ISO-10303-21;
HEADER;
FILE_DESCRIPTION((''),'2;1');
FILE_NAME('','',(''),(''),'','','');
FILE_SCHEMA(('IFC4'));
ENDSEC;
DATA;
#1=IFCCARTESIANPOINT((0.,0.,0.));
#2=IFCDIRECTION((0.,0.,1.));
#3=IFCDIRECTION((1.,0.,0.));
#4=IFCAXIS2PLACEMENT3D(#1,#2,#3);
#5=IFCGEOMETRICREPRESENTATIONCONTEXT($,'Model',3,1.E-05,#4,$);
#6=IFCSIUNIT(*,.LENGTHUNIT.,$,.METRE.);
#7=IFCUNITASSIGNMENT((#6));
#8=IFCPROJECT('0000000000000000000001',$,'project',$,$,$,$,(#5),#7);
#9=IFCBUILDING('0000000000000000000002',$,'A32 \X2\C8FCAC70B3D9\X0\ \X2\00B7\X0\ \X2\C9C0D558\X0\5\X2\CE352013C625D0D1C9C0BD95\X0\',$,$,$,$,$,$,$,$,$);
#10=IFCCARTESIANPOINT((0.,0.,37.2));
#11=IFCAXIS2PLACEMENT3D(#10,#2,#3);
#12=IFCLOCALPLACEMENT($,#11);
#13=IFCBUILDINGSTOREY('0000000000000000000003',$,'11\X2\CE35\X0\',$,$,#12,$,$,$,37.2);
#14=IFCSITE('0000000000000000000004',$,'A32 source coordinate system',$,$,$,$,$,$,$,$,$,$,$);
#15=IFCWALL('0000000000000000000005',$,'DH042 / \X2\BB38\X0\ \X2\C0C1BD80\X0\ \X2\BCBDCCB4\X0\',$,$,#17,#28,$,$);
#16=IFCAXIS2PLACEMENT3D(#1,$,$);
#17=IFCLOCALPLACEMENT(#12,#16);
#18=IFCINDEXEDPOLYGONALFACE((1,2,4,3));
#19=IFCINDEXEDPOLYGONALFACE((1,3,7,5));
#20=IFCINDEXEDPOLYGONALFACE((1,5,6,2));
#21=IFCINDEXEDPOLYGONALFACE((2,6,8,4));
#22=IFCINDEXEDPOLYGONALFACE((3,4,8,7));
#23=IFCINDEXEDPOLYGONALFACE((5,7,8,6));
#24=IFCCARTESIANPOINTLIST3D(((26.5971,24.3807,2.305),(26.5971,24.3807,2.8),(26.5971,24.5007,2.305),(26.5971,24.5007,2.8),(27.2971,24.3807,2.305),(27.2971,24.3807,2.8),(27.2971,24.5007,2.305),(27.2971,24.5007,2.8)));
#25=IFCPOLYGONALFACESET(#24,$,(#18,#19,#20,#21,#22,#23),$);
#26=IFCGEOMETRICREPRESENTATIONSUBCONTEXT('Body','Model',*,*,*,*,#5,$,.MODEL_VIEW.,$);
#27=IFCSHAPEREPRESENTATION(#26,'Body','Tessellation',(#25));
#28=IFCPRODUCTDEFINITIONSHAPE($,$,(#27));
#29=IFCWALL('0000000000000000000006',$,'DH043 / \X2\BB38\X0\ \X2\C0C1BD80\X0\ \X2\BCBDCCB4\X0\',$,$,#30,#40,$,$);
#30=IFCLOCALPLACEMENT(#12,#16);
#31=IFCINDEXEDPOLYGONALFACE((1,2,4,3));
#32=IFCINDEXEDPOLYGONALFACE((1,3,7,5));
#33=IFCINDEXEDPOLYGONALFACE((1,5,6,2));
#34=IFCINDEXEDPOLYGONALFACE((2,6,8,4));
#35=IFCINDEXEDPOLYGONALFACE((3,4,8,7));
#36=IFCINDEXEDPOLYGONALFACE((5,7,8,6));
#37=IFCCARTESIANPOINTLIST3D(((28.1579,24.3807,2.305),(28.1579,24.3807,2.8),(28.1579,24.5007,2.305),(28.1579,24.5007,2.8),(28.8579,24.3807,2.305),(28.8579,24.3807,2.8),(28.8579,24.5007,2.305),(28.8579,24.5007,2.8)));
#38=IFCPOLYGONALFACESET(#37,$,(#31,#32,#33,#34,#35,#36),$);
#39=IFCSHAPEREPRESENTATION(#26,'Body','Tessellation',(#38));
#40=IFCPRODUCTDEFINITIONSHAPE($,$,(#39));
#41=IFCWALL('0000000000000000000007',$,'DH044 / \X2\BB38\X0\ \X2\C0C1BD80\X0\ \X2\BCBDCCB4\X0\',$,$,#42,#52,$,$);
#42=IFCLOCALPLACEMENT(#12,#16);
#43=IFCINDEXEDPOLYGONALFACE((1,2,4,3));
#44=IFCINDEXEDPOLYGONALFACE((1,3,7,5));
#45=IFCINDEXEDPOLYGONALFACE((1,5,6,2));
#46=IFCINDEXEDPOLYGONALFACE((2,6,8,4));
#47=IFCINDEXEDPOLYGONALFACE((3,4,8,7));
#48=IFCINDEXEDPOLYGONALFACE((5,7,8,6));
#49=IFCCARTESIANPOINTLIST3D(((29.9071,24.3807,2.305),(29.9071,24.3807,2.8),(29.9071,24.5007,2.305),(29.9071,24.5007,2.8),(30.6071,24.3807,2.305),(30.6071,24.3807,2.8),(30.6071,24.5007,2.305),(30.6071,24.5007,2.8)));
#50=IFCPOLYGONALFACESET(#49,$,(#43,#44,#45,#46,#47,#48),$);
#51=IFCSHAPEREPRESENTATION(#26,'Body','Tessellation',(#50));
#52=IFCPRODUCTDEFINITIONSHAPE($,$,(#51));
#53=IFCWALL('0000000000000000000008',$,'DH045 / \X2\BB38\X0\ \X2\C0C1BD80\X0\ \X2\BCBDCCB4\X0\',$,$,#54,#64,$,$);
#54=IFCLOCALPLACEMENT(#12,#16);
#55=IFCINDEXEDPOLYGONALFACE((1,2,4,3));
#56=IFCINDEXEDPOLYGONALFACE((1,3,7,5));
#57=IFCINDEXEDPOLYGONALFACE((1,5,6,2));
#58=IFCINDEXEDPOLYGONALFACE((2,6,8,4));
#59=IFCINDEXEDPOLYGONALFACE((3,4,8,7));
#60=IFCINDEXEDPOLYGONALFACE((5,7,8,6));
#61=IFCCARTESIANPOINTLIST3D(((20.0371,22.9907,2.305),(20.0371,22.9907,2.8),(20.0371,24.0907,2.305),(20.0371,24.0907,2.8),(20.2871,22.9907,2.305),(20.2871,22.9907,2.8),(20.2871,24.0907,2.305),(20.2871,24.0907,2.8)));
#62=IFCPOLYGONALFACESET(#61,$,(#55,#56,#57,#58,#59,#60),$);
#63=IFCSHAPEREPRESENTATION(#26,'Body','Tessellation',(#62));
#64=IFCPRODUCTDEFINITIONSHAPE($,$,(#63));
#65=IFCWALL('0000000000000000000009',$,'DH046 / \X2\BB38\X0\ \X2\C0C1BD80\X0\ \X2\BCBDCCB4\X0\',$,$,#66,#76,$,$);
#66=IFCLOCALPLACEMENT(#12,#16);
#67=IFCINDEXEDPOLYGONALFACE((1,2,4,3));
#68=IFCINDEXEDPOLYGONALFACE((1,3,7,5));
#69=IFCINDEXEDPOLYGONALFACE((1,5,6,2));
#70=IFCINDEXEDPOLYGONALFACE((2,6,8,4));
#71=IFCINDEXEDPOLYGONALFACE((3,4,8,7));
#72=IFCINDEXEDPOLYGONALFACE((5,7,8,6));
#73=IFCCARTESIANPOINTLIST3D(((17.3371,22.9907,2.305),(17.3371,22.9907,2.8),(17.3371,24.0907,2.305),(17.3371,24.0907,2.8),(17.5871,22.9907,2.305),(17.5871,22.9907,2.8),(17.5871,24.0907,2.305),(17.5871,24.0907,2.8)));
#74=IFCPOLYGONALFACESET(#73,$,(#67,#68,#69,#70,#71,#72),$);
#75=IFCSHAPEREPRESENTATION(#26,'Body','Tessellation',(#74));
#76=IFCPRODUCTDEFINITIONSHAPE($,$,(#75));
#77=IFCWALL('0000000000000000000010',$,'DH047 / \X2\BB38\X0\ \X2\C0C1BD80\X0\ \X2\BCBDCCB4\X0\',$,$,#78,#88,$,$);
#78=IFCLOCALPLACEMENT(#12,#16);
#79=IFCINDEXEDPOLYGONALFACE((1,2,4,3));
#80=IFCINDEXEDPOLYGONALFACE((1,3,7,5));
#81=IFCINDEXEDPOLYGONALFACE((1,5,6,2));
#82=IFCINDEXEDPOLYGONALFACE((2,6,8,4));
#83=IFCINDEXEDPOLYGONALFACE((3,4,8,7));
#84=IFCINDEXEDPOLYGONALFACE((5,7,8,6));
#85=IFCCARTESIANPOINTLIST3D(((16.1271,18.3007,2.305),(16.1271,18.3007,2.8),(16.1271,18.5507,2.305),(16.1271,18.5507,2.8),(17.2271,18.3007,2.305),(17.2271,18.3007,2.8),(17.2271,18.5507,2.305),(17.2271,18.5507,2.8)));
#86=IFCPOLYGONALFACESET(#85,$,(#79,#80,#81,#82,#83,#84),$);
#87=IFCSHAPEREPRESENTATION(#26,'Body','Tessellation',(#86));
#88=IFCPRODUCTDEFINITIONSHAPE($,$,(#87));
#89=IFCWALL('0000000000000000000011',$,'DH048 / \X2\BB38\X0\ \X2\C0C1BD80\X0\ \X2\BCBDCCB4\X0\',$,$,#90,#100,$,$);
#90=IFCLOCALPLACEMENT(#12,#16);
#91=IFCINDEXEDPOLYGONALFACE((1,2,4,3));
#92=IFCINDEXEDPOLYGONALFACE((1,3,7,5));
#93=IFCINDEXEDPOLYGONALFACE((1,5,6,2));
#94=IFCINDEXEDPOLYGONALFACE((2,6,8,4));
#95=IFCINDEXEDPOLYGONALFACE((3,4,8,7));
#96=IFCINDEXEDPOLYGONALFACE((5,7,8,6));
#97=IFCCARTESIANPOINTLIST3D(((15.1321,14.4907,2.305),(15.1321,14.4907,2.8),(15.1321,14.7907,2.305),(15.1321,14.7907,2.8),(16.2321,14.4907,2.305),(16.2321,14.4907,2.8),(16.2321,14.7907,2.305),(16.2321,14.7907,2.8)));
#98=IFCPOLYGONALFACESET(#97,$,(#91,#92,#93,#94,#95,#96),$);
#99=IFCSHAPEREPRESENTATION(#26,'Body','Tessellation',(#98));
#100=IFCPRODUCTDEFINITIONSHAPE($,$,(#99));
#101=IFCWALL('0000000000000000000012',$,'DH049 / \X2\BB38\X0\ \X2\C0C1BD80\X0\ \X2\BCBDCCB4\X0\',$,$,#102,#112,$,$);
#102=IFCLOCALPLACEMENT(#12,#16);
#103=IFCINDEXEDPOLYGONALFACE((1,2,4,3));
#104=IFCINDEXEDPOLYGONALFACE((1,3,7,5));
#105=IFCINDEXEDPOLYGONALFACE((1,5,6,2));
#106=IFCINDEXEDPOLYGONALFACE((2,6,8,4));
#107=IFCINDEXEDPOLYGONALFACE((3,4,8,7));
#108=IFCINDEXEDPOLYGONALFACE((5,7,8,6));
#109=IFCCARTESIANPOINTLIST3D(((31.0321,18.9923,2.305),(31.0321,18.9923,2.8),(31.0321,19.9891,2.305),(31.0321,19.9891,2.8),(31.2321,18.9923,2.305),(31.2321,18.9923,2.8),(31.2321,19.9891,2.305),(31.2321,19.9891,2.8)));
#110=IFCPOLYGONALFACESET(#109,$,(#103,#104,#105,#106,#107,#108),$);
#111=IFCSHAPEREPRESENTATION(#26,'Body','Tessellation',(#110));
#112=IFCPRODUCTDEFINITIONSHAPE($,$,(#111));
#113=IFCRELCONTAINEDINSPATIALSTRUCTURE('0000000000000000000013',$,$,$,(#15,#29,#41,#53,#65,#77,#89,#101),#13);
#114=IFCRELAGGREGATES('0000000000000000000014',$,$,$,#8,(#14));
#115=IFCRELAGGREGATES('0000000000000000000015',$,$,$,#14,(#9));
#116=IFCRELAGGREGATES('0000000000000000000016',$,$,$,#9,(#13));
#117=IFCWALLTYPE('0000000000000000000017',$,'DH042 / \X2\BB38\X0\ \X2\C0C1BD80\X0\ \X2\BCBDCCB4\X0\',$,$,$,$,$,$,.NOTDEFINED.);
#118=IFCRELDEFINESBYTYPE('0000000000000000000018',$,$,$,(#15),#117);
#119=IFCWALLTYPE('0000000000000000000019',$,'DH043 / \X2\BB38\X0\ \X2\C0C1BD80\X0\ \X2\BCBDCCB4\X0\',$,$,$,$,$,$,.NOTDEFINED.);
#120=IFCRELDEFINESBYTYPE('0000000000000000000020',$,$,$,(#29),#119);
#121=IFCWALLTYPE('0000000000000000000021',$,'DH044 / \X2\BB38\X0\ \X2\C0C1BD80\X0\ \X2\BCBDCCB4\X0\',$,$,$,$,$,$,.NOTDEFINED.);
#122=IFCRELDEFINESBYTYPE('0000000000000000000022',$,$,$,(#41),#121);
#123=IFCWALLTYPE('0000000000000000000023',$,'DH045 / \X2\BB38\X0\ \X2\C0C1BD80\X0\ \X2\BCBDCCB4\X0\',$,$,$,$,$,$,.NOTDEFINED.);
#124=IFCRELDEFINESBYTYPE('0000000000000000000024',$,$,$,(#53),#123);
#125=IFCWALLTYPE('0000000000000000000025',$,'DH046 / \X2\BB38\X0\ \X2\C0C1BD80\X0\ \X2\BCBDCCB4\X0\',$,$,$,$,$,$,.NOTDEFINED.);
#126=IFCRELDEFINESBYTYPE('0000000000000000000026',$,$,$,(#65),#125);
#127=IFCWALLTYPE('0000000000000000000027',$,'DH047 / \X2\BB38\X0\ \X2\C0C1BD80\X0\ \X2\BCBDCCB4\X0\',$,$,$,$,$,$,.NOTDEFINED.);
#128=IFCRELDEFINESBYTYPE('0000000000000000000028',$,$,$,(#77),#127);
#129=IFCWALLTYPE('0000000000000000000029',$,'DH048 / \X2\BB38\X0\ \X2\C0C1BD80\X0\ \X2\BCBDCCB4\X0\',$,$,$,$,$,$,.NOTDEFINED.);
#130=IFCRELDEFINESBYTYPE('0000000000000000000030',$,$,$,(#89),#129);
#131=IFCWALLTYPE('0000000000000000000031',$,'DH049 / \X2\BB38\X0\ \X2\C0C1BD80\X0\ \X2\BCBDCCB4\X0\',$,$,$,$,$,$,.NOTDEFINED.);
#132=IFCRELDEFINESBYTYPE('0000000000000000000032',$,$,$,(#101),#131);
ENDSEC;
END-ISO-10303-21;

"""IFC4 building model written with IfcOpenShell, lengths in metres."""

from ifc_helpers import new_model, si_unit, frame, origin, origin_with_axes, place, context, subcontext, project, spatial, polyline, outline, extrude, source, transform, mapped, type_object, type_shapes, element, save


model = new_model("IFC4")

# Units and contexts
model_context = context("Model", 3, precision=1e-05, world=origin_with_axes())
body_context = subcontext(model_context, "Body", "Model", "MODEL_VIEW")
ifc_project = project(units=[si_unit("LENGTHUNIT", "METRE")], contexts=[model_context])

# Site, building, storey
site = spatial("IfcSite", under=ifc_project, Name="A32 source coordinate system")
building = spatial("IfcBuilding", under=site, Name="A32 주거동 · 지하5층–옥탑지붕")
storey_placement = place(None, frame((0.0, 0.0, 37.2), z_axis=(0.0, 0.0, 1.0), x_axis=(1.0, 0.0, 0.0)))
storey = spatial("IfcBuildingStorey", under=building, at=storey_placement, Name="11층", Elevation=37.2)

# Walls
wall_type_1 = type_object("IfcWallType", Name="DH042 / 문 상부 벽체", PredefinedType="NOTDEFINED")
shared_shape_1 = source(origin(), body_context, "Body", "SweptSolid", [
    extrude(outline(polyline([(27.2971, 24.3807), (26.5971, 24.3807), (26.5971, 24.5007), (27.2971, 24.5007), (27.2971, 24.3807)])), frame((0.0, 0.0, 2.305)), (0.0, 0.0, 1.0), 0.495),
])
type_shapes(wall_type_1, [shared_shape_1])
wall_1_placement = place(storey_placement, origin_with_axes())
element("IfcWall", 1, at=wall_1_placement, inside=storey, type_object=wall_type_1, Name="DH042 / 문 상부 벽체", context=body_context, shape_type="MappedRepresentation", body=[
    mapped(shared_shape_1, transform((0.0, 0.0, 0.0), scale=1.0)),
])
wall_type_2 = type_object("IfcWallType", Name="DH043 / 문 상부 벽체", PredefinedType="NOTDEFINED")
shared_shape_2 = source(origin(), body_context, "Body", "SweptSolid", [
    extrude(outline(polyline([(28.8579, 24.3807), (28.1579, 24.3807), (28.1579, 24.5007), (28.8579, 24.5007), (28.8579, 24.3807)])), frame((0.0, 0.0, 2.305)), (0.0, 0.0, 1.0), 0.495),
])
type_shapes(wall_type_2, [shared_shape_2])
wall_2_placement = place(storey_placement, origin_with_axes())
element("IfcWall", 2, at=wall_2_placement, inside=storey, type_object=wall_type_2, Name="DH043 / 문 상부 벽체", context=body_context, shape_type="MappedRepresentation", body=[
    mapped(shared_shape_2, transform((0.0, 0.0, 0.0), scale=1.0)),
])
wall_type_3 = type_object("IfcWallType", Name="DH044 / 문 상부 벽체", PredefinedType="NOTDEFINED")
shared_shape_3 = source(origin(), body_context, "Body", "SweptSolid", [
    extrude(outline(polyline([(30.6071, 24.3807), (29.9071, 24.3807), (29.9071, 24.5007), (30.6071, 24.5007), (30.6071, 24.3807)])), frame((0.0, 0.0, 2.305)), (0.0, 0.0, 1.0), 0.495),
])
type_shapes(wall_type_3, [shared_shape_3])
wall_3_placement = place(storey_placement, origin_with_axes())
element("IfcWall", 3, at=wall_3_placement, inside=storey, type_object=wall_type_3, Name="DH044 / 문 상부 벽체", context=body_context, shape_type="MappedRepresentation", body=[
    mapped(shared_shape_3, transform((0.0, 0.0, 0.0), scale=1.0)),
])
wall_type_4 = type_object("IfcWallType", Name="DH045 / 문 상부 벽체", PredefinedType="NOTDEFINED")
shared_shape_4 = source(origin(), body_context, "Body", "SweptSolid", [
    extrude(outline(polyline([(20.2871, 22.9907), (20.0371, 22.9907), (20.0371, 24.0907), (20.2871, 24.0907), (20.2871, 22.9907)])), frame((0.0, 0.0, 2.305)), (0.0, 0.0, 1.0), 0.495),
])
type_shapes(wall_type_4, [shared_shape_4])
wall_4_placement = place(storey_placement, origin_with_axes())
element("IfcWall", 4, at=wall_4_placement, inside=storey, type_object=wall_type_4, Name="DH045 / 문 상부 벽체", context=body_context, shape_type="MappedRepresentation", body=[
    mapped(shared_shape_4, transform((0.0, 0.0, 0.0), scale=1.0)),
])
wall_type_5 = type_object("IfcWallType", Name="DH046 / 문 상부 벽체", PredefinedType="NOTDEFINED")
shared_shape_5 = source(origin(), body_context, "Body", "SweptSolid", [
    extrude(outline(polyline([(17.5871, 22.9907), (17.3371, 22.9907), (17.3371, 24.0907), (17.5871, 24.0907), (17.5871, 22.9907)])), frame((0.0, 0.0, 2.305)), (0.0, 0.0, 1.0), 0.495),
])
type_shapes(wall_type_5, [shared_shape_5])
wall_5_placement = place(storey_placement, origin_with_axes())
element("IfcWall", 5, at=wall_5_placement, inside=storey, type_object=wall_type_5, Name="DH046 / 문 상부 벽체", context=body_context, shape_type="MappedRepresentation", body=[
    mapped(shared_shape_5, transform((0.0, 0.0, 0.0), scale=1.0)),
])
wall_type_6 = type_object("IfcWallType", Name="DH047 / 문 상부 벽체", PredefinedType="NOTDEFINED")
shared_shape_6 = source(origin(), body_context, "Body", "SweptSolid", [
    extrude(outline(polyline([(17.2271, 18.3007), (16.1271, 18.3007), (16.1271, 18.5507), (17.2271, 18.5507), (17.2271, 18.3007)])), frame((0.0, 0.0, 2.305)), (0.0, 0.0, 1.0), 0.495),
])
type_shapes(wall_type_6, [shared_shape_6])
wall_6_placement = place(storey_placement, origin_with_axes())
element("IfcWall", 6, at=wall_6_placement, inside=storey, type_object=wall_type_6, Name="DH047 / 문 상부 벽체", context=body_context, shape_type="MappedRepresentation", body=[
    mapped(shared_shape_6, transform((0.0, 0.0, 0.0), scale=1.0)),
])
wall_type_7 = type_object("IfcWallType", Name="DH048 / 문 상부 벽체", PredefinedType="NOTDEFINED")
shared_shape_7 = source(origin(), body_context, "Body", "SweptSolid", [
    extrude(outline(polyline([(15.1321, 14.7907), (16.2321, 14.7907), (16.2321, 14.4907), (15.1321, 14.4907), (15.1321, 14.7907)])), frame((0.0, 0.0, 2.305)), (0.0, 0.0, 1.0), 0.495),
])
type_shapes(wall_type_7, [shared_shape_7])
wall_7_placement = place(storey_placement, origin_with_axes())
element("IfcWall", 7, at=wall_7_placement, inside=storey, type_object=wall_type_7, Name="DH048 / 문 상부 벽체", context=body_context, shape_type="MappedRepresentation", body=[
    mapped(shared_shape_7, transform((0.0, 0.0, 0.0), scale=1.0)),
])
wall_type_8 = type_object("IfcWallType", Name="DH049 / 문 상부 벽체", PredefinedType="NOTDEFINED")
shared_shape_8 = source(origin(), body_context, "Body", "SweptSolid", [
    extrude(outline(polyline([(31.2321, 18.9923), (31.0321, 18.9923), (31.0321, 19.9891), (31.2321, 19.9891), (31.2321, 18.9923)])), frame((0.0, 0.0, 2.305)), (0.0, 0.0, 1.0), 0.495),
])
type_shapes(wall_type_8, [shared_shape_8])
wall_8_placement = place(storey_placement, origin_with_axes())
element("IfcWall", 8, at=wall_8_placement, inside=storey, type_object=wall_type_8, Name="DH049 / 문 상부 벽체", context=body_context, shape_type="MappedRepresentation", body=[
    mapped(shared_shape_8, transform((0.0, 0.0, 0.0), scale=1.0)),
])

save(model, "model.ifc")
